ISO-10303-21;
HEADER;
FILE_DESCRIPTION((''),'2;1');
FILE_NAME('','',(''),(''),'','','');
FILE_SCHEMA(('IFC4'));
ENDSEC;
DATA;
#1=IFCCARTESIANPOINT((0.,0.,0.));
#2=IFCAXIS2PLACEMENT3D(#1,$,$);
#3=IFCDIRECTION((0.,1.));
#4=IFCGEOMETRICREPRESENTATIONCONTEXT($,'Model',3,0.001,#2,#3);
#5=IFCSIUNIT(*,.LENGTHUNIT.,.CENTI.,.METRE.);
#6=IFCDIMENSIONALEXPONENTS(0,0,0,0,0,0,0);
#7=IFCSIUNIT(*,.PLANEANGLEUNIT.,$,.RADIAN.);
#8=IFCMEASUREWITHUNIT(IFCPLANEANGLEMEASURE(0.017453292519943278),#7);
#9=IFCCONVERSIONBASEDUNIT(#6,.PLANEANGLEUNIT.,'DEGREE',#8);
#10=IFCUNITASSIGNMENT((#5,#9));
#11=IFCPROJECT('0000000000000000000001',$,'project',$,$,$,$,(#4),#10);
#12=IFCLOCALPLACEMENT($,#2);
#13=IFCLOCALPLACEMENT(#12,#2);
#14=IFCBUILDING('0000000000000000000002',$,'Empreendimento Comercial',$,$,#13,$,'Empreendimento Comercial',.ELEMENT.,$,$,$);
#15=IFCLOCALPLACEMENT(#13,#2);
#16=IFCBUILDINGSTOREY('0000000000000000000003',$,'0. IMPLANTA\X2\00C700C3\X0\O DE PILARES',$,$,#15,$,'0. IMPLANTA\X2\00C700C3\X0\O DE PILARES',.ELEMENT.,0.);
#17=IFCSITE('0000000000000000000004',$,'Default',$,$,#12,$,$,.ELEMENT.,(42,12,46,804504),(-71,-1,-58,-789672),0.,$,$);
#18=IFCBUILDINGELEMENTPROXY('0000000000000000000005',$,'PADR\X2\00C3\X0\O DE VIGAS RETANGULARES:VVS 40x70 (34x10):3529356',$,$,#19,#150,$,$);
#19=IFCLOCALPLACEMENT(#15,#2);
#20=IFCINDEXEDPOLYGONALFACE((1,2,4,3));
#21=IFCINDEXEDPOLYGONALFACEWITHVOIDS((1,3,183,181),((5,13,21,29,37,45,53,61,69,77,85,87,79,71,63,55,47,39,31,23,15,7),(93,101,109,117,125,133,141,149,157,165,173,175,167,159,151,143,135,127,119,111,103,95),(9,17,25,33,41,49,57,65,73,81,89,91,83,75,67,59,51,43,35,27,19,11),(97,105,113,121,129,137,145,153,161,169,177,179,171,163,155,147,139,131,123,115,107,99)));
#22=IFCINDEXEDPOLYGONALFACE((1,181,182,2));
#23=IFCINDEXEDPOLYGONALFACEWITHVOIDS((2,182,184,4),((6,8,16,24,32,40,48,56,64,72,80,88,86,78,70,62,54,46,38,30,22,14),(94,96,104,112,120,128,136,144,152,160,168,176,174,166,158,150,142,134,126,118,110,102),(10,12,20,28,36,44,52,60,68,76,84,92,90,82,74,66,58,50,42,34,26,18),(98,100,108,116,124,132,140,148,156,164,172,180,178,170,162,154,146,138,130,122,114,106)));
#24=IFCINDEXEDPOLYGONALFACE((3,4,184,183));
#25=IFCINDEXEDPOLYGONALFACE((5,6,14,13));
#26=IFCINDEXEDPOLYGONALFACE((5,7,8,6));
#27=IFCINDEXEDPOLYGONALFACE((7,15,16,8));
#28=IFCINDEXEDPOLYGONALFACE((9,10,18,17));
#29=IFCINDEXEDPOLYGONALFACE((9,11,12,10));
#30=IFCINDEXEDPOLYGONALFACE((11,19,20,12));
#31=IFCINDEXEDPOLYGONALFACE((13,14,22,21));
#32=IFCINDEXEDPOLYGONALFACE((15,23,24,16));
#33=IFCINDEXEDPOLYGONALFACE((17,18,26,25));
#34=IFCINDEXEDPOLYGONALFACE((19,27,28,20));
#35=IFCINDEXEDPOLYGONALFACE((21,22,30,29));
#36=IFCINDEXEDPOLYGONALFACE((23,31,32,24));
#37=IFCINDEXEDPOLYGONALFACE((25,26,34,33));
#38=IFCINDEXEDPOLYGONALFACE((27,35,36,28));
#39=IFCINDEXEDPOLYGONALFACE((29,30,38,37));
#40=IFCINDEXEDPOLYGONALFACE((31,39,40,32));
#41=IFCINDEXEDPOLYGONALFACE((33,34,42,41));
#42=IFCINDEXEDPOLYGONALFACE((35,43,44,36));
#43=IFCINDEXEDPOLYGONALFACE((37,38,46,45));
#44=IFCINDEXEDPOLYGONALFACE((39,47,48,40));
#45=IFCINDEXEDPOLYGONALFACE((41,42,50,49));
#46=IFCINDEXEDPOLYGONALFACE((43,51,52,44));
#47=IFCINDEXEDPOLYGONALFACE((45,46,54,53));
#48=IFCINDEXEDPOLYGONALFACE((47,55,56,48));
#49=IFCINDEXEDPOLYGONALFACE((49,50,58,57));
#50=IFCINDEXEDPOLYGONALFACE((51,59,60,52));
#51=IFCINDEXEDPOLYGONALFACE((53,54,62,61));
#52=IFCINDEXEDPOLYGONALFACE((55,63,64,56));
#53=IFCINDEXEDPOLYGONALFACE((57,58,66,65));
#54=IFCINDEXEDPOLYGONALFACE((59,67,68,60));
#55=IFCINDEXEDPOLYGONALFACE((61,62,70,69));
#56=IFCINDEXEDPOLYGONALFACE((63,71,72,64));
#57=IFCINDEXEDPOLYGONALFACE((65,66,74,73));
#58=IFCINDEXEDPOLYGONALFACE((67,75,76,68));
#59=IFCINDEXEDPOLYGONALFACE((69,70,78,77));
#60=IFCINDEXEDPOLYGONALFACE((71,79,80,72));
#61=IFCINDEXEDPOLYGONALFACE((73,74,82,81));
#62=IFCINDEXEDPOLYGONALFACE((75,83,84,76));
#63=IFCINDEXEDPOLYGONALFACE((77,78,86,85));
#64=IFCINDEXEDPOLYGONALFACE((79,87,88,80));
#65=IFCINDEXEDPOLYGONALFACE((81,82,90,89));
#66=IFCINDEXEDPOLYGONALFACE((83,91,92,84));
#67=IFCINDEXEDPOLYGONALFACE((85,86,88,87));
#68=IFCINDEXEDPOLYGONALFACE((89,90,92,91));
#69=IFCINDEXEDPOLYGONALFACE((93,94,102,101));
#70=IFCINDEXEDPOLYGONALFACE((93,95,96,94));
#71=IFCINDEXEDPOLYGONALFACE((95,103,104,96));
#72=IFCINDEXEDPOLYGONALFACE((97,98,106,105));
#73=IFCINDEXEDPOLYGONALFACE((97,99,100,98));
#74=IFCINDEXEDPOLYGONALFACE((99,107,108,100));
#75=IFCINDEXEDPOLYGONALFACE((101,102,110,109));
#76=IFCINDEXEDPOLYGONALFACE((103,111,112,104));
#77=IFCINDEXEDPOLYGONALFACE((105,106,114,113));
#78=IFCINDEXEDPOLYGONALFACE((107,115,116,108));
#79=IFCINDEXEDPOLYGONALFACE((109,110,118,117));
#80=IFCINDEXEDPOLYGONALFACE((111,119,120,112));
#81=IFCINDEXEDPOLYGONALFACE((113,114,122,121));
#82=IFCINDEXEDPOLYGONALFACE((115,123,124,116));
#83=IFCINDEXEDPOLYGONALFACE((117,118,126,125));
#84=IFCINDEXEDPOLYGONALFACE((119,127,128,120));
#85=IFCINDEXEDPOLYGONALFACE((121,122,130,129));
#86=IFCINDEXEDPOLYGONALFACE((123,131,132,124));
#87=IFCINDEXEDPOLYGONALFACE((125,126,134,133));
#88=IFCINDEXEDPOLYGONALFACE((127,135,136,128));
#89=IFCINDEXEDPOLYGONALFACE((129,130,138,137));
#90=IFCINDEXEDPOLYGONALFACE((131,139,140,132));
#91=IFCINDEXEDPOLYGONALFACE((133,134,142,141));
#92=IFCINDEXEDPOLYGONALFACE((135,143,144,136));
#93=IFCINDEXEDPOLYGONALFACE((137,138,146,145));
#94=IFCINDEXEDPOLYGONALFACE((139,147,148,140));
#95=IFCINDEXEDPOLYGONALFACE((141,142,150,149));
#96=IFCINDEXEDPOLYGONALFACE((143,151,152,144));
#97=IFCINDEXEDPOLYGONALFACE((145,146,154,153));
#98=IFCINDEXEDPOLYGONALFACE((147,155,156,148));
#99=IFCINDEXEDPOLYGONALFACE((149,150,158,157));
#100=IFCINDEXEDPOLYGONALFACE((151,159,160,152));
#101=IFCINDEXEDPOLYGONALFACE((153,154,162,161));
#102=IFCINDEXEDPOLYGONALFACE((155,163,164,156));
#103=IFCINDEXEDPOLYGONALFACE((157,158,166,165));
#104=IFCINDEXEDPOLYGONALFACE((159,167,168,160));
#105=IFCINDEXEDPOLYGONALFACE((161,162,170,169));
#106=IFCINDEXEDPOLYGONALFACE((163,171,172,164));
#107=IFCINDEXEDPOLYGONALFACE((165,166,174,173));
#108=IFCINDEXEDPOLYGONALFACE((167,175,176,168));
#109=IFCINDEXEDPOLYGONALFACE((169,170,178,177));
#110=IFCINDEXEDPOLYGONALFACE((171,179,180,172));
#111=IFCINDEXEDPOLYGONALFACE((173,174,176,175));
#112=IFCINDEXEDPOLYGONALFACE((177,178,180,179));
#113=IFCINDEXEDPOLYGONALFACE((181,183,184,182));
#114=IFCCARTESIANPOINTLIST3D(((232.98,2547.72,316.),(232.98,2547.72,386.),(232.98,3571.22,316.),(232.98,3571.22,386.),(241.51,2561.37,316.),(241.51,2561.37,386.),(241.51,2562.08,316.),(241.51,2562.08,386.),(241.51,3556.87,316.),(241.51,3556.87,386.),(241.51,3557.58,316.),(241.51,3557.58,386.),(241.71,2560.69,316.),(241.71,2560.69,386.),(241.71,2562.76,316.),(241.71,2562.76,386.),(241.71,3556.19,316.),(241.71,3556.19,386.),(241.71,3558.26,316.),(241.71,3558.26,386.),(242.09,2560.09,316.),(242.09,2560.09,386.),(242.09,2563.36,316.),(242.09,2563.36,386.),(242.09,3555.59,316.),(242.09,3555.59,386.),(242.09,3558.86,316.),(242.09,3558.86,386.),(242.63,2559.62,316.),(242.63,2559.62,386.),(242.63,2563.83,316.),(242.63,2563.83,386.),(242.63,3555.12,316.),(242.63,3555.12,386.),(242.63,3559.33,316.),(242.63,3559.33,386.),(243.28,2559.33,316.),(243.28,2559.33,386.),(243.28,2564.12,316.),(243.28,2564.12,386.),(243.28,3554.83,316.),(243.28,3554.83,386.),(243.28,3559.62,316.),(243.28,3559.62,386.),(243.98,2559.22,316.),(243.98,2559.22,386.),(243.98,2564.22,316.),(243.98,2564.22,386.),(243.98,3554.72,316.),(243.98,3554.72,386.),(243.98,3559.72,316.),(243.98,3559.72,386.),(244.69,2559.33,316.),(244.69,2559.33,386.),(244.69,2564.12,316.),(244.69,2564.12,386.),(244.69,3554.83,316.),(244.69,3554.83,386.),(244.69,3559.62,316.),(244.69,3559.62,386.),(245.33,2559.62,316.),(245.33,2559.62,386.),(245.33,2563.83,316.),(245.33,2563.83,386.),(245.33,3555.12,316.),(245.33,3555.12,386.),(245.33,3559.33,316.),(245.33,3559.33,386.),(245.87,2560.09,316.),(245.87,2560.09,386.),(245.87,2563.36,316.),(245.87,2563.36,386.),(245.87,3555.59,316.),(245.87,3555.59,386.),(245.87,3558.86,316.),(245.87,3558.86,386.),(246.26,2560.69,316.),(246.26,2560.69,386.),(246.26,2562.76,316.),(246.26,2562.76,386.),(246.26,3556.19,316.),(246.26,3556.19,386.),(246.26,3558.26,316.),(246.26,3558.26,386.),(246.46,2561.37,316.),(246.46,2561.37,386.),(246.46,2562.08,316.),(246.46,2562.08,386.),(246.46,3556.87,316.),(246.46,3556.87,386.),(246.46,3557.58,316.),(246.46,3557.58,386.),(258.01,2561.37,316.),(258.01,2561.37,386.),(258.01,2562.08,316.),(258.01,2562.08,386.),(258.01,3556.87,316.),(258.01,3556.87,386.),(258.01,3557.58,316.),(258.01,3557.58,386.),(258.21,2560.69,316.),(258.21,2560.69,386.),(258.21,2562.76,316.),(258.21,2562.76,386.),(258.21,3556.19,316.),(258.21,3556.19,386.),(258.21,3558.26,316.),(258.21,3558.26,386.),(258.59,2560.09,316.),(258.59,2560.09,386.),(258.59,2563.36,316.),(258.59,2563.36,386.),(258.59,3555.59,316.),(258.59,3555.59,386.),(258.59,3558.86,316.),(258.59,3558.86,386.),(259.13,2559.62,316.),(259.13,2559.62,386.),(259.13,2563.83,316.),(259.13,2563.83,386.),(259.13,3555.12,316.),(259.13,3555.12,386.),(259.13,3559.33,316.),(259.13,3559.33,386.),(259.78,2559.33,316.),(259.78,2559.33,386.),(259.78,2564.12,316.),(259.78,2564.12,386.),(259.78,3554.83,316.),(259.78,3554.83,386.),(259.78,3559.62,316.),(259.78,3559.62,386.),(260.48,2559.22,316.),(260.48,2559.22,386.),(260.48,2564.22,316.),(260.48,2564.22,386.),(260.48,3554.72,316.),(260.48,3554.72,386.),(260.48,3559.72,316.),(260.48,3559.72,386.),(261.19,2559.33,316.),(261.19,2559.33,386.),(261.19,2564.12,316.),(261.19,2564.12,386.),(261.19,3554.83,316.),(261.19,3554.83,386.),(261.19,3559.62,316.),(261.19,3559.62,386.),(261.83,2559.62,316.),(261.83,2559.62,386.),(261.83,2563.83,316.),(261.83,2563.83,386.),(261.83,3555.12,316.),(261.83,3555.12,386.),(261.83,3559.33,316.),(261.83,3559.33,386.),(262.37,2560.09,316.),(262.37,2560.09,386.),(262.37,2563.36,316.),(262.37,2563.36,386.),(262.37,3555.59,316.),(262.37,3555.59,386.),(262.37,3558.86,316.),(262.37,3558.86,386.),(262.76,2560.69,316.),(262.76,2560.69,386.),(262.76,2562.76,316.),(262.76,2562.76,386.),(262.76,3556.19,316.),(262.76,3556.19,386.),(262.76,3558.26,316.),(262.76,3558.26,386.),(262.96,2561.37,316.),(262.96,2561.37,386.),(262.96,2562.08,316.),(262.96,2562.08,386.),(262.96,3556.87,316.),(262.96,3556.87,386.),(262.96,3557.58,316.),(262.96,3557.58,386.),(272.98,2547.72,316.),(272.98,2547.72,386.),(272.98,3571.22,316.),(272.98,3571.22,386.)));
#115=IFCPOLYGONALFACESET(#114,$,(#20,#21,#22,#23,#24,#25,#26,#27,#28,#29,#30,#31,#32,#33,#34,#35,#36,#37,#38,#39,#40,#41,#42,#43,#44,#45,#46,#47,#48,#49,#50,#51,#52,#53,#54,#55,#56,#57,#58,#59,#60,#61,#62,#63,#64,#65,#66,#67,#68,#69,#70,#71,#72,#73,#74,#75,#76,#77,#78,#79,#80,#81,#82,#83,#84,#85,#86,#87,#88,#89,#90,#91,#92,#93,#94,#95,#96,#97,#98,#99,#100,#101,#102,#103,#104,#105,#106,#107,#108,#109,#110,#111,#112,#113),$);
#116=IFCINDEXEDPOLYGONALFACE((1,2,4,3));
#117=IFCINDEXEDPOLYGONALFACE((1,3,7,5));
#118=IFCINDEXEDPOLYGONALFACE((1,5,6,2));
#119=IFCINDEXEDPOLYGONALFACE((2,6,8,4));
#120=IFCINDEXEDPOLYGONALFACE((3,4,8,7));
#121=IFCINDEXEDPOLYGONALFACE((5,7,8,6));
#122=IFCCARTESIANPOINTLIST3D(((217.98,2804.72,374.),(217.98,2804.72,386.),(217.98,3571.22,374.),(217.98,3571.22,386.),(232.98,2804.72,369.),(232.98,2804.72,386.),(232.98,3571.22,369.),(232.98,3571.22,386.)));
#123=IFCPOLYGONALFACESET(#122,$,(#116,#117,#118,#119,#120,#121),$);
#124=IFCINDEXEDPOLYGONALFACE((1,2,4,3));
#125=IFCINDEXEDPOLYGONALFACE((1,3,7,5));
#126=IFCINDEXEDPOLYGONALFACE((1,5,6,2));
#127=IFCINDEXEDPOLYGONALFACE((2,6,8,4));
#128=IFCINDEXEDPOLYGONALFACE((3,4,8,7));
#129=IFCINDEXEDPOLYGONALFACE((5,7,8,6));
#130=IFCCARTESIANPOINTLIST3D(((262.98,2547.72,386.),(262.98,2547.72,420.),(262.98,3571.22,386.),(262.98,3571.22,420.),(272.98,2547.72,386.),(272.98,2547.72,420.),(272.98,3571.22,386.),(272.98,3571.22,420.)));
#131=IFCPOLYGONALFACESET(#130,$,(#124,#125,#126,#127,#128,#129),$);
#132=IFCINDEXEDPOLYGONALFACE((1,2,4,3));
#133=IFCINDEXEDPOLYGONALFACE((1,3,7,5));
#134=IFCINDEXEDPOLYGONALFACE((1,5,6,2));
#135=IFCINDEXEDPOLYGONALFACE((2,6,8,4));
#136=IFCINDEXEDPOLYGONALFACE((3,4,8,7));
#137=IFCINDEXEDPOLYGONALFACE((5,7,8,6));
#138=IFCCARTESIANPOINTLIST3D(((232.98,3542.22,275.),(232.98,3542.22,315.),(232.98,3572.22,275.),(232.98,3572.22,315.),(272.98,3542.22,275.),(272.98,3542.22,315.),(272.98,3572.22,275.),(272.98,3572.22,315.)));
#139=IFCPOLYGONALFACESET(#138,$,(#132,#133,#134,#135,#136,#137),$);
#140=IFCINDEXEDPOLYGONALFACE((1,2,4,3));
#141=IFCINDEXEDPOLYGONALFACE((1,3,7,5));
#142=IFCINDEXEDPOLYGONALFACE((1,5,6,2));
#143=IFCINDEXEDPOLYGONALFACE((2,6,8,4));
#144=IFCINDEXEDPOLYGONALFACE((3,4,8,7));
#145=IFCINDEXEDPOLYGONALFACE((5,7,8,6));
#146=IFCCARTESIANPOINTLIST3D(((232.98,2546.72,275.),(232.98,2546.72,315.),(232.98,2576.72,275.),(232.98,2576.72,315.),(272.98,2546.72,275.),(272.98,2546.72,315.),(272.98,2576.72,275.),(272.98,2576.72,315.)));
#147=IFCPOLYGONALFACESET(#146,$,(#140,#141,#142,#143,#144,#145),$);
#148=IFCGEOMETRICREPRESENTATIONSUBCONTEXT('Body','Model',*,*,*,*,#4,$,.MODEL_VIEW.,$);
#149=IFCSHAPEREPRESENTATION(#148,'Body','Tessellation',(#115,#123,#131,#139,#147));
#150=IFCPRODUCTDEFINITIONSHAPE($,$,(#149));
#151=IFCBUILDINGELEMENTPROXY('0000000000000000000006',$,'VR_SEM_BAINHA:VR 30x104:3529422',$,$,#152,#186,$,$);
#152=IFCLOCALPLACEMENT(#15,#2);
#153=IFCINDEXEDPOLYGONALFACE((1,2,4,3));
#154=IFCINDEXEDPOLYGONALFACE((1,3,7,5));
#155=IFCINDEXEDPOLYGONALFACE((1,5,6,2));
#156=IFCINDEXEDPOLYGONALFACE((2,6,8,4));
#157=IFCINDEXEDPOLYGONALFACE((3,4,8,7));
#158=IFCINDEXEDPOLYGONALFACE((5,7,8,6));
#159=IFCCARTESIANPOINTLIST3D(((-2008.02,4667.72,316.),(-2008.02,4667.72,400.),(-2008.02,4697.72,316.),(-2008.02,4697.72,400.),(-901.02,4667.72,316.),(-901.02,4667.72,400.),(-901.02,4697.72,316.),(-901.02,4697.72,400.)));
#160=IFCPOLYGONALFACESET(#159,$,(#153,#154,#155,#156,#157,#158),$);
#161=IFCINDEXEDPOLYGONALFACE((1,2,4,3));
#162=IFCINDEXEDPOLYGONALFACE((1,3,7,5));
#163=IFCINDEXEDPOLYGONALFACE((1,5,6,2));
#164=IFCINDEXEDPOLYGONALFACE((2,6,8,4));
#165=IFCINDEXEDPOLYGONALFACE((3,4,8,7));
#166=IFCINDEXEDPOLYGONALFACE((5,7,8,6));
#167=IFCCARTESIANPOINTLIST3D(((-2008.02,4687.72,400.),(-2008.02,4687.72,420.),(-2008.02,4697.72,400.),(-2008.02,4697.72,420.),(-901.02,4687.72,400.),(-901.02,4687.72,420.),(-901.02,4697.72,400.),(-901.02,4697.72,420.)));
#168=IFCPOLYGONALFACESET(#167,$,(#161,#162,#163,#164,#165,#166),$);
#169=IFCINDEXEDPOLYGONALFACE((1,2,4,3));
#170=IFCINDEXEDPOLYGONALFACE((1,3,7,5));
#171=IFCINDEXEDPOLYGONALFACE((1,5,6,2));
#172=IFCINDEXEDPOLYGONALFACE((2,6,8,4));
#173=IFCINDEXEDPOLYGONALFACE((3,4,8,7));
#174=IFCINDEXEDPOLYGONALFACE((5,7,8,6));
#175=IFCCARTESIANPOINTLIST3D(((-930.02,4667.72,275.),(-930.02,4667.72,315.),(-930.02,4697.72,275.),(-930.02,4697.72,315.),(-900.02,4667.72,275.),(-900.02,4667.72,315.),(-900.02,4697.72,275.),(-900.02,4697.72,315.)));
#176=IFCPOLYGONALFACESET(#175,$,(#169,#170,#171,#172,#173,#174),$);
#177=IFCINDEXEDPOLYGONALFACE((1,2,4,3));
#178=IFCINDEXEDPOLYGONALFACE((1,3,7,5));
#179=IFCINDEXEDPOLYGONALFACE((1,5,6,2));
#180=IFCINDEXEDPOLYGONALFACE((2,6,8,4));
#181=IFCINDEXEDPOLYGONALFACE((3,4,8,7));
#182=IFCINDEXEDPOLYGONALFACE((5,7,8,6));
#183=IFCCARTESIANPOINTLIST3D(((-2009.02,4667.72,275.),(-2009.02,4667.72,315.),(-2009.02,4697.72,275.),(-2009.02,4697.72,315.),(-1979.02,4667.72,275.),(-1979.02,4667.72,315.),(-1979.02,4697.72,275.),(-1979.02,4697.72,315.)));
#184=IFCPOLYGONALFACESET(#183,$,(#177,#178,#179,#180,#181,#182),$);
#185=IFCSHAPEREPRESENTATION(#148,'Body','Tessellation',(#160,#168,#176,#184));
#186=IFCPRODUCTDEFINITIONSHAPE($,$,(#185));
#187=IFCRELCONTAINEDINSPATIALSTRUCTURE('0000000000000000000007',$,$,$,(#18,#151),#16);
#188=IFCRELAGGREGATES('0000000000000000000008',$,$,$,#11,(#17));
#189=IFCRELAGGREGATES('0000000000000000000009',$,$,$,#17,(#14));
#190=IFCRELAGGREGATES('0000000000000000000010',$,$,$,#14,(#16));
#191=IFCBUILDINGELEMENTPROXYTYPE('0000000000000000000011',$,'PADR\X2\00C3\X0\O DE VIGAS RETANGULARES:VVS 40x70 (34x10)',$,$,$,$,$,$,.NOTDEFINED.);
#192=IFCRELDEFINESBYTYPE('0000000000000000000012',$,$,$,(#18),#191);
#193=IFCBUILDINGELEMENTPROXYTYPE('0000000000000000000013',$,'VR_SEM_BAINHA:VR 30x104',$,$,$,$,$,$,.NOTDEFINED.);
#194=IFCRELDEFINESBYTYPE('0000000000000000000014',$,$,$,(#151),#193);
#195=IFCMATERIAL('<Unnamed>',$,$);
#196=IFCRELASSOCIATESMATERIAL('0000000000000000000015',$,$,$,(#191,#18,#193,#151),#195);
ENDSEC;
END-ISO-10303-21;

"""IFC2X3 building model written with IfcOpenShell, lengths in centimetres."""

from ifc_helpers import new_model, entity, si_unit, converted_unit, direction, frame, frame_2d, origin, origin_2d_with_axis, place, context, subcontext, project, spatial, polyline, circle_curve, parameter, trimmed, segment, composite_curve, rectangle, outline, extrude, source, transform, mapped, material, type_object, type_shapes, element, save


model = new_model("IFC2X3")

# Units and contexts
model_context = context("Model", 3, precision=0.001, world=origin(), true_north=direction((0.0, 1.0)))
body_context = subcontext(model_context, "Body", "Model", "MODEL_VIEW")
ifc_project = project(units=[si_unit("LENGTHUNIT", "METRE", prefix="CENTI"), converted_unit("PLANEANGLEUNIT", "DEGREE", entity("IfcPlaneAngleMeasure", 0.017453292519943278), si_unit("PLANEANGLEUNIT", "RADIAN"), dimensions=[0, 0, 0, 0, 0, 0, 0])], contexts=[model_context])

# Site, building, storey
site_placement = place(None, origin())
site = spatial("IfcSite", under=ifc_project, at=site_placement, Name="Default", CompositionType="ELEMENT", RefLatitude=(42, 12, 46, 804504), RefLongitude=(-71, -1, -58, -789672), RefElevation=0.0)
building_placement = place(site_placement, origin())
building = spatial("IfcBuilding", under=site, at=building_placement, Name="Empreendimento Comercial", LongName="Empreendimento Comercial", CompositionType="ELEMENT")
storey_placement = place(building_placement, origin())
storey = spatial("IfcBuildingStorey", under=building, at=storey_placement, Name="0. IMPLANTAÇÃO DE PILARES", LongName="0. IMPLANTAÇÃO DE PILARES", CompositionType="ELEMENT", Elevation=0.0)

# Building element proxies
ifc_material_1 = material(Name="<Unnamed>")
building_element_proxy_type_1 = type_object("IfcBuildingElementProxyType", Name="PADRÃO DE VIGAS RETANGULARES:VVS 40x70 (34x10)", PredefinedType="NOTDEFINED", material=ifc_material_1)
shared_shape_1 = source(origin(), body_context, "Body", "SweptSolid", [
    extrude(outline(polyline([(-511.75, -20.0), (511.75, -20.0), (511.75, 20.0), (-511.75, 20.0), (-511.75, -20.0)]), holes=[composite_curve([segment(trimmed(circle_curve(frame_2d((-497.75, -7.5), x_axis=(-1.0, 0.0)), 2.5), [parameter(0.0)], [parameter(180.0)], True, "PARAMETER"), False, "CONTINUOUS"), segment(trimmed(circle_curve(frame_2d((-497.75, -7.5), x_axis=(-1.0, 0.0)), 2.5), [parameter(180.0)], [parameter(0.0)], True, "PARAMETER"), False, "CONTINUOUS")], self_intersect=False), composite_curve([segment(trimmed(circle_curve(frame_2d((-497.75, 9.0), x_axis=(-1.0, 0.0)), 2.5), [parameter(0.0)], [parameter(180.0)], True, "PARAMETER"), False, "CONTINUOUS"), segment(trimmed(circle_curve(frame_2d((-497.75, 9.0), x_axis=(-1.0, 0.0)), 2.5), [parameter(180.0)], [parameter(0.0)], True, "PARAMETER"), False, "CONTINUOUS")], self_intersect=False), composite_curve([segment(trimmed(circle_curve(frame_2d((497.75, 9.0), x_axis=(-1.0, 0.0)), 2.5), [parameter(0.0)], [parameter(180.0)], True, "PARAMETER"), False, "CONTINUOUS"), segment(trimmed(circle_curve(frame_2d((497.75, 9.0), x_axis=(-1.0, 0.0)), 2.5), [parameter(180.0)], [parameter(0.0)], True, "PARAMETER"), False, "CONTINUOUS")], self_intersect=False), composite_curve([segment(trimmed(circle_curve(frame_2d((497.75, -7.5), x_axis=(-1.0, 0.0)), 2.5), [parameter(0.0)], [parameter(180.0)], True, "PARAMETER"), False, "CONTINUOUS"), segment(trimmed(circle_curve(frame_2d((497.75, -7.5), x_axis=(-1.0, 0.0)), 2.5), [parameter(180.0)], [parameter(0.0)], True, "PARAMETER"), False, "CONTINUOUS")], self_intersect=False)]), frame((252.98, 3059.47, 316.0), z_axis=(0.0, 0.0, 1.0), x_axis=(0.0, 1.0, 0.0)), (0.0, 0.0, 1.0), 70.0),
    extrude(outline(polyline([(-4.75, -7.5), (7.25, -7.5), (7.25, 7.5), (-9.75, 7.5), (-4.75, -7.5)])), frame((225.48, 2804.72, 378.75), z_axis=(0.0, 1.0, 0.0), x_axis=(0.0, 0.0, 1.0)), (0.0, 0.0, 1.0), 766.5),
    extrude(rectangle(XDim=1023.5, YDim=10.0, at=frame_2d((0.0, 0.0), x_axis=(1.0, 0.0))), frame((267.98, 3059.47, 386.0), z_axis=(0.0, 0.0, 1.0), x_axis=(0.0, 1.0, 0.0)), (0.0, 0.0, 1.0), 34.0),
    extrude(rectangle(XDim=40.0, YDim=30.0, at=frame_2d((0.0, 0.0), x_axis=(1.0, 0.0))), frame((252.98, 3557.22, 275.0)), (0.0, 0.0, 1.0), 40.0),
    extrude(rectangle(XDim=40.0, YDim=30.0, at=frame_2d((0.0, 0.0), x_axis=(1.0, 0.0))), frame((252.98, 2561.72, 275.0)), (0.0, 0.0, 1.0), 40.0),
])
type_shapes(building_element_proxy_type_1, [shared_shape_1])
proxy_1_placement = place(storey_placement, origin())
element("IfcBuildingElementProxy", 1, at=proxy_1_placement, inside=storey, type_object=building_element_proxy_type_1, material=ifc_material_1, Name="PADRÃO DE VIGAS RETANGULARES:VVS 40x70 (34x10):3529356", context=body_context, shape_type="MappedRepresentation", body=[
    mapped(shared_shape_1, transform((0.0, 0.0, 0.0), scale=1.0)),
])
building_element_proxy_type_2 = type_object("IfcBuildingElementProxyType", Name="VR_SEM_BAINHA:VR 30x104", PredefinedType="NOTDEFINED", material=ifc_material_1)
shared_shape_2 = source(origin(), body_context, "Body", "SweptSolid", [
    extrude(rectangle(XDim=30.0, YDim=1107.0, at=frame_2d((0.0, 0.0), x_axis=(1.0, 0.0))), frame((-1454.52, 4682.72, 316.0), z_axis=(0.0, 0.0, 1.0), x_axis=(0.0, -1.0, 0.0)), (0.0, 0.0, 1.0), 84.0),
    extrude(rectangle(XDim=10.0, YDim=1107.0, at=frame_2d((0.0, 0.0), x_axis=(1.0, 0.0))), frame((-1454.52, 4692.72, 400.0), z_axis=(0.0, 0.0, 1.0), x_axis=(0.0, -1.0, 0.0)), (0.0, 0.0, 1.0), 20.0),
    extrude(rectangle(XDim=30.0, YDim=30.0, at=frame_2d((0.0, 0.0), x_axis=(1.0, 0.0))), frame((-915.02, 4682.72, 275.0)), (0.0, 0.0, 1.0), 40.0),
    extrude(rectangle(XDim=30.0, YDim=30.0, at=origin_2d_with_axis()), frame((-1994.02, 4682.72, 275.0)), (0.0, 0.0, 1.0), 40.0),
])
type_shapes(building_element_proxy_type_2, [shared_shape_2])
proxy_2_placement = place(storey_placement, origin())
element("IfcBuildingElementProxy", 2, at=proxy_2_placement, inside=storey, type_object=building_element_proxy_type_2, material=ifc_material_1, Name="VR_SEM_BAINHA:VR 30x104:3529422", context=body_context, shape_type="MappedRepresentation", body=[
    mapped(shared_shape_2, transform((0.0, 0.0, 0.0), scale=1.0)),
])

save(model, "model.ifc")
